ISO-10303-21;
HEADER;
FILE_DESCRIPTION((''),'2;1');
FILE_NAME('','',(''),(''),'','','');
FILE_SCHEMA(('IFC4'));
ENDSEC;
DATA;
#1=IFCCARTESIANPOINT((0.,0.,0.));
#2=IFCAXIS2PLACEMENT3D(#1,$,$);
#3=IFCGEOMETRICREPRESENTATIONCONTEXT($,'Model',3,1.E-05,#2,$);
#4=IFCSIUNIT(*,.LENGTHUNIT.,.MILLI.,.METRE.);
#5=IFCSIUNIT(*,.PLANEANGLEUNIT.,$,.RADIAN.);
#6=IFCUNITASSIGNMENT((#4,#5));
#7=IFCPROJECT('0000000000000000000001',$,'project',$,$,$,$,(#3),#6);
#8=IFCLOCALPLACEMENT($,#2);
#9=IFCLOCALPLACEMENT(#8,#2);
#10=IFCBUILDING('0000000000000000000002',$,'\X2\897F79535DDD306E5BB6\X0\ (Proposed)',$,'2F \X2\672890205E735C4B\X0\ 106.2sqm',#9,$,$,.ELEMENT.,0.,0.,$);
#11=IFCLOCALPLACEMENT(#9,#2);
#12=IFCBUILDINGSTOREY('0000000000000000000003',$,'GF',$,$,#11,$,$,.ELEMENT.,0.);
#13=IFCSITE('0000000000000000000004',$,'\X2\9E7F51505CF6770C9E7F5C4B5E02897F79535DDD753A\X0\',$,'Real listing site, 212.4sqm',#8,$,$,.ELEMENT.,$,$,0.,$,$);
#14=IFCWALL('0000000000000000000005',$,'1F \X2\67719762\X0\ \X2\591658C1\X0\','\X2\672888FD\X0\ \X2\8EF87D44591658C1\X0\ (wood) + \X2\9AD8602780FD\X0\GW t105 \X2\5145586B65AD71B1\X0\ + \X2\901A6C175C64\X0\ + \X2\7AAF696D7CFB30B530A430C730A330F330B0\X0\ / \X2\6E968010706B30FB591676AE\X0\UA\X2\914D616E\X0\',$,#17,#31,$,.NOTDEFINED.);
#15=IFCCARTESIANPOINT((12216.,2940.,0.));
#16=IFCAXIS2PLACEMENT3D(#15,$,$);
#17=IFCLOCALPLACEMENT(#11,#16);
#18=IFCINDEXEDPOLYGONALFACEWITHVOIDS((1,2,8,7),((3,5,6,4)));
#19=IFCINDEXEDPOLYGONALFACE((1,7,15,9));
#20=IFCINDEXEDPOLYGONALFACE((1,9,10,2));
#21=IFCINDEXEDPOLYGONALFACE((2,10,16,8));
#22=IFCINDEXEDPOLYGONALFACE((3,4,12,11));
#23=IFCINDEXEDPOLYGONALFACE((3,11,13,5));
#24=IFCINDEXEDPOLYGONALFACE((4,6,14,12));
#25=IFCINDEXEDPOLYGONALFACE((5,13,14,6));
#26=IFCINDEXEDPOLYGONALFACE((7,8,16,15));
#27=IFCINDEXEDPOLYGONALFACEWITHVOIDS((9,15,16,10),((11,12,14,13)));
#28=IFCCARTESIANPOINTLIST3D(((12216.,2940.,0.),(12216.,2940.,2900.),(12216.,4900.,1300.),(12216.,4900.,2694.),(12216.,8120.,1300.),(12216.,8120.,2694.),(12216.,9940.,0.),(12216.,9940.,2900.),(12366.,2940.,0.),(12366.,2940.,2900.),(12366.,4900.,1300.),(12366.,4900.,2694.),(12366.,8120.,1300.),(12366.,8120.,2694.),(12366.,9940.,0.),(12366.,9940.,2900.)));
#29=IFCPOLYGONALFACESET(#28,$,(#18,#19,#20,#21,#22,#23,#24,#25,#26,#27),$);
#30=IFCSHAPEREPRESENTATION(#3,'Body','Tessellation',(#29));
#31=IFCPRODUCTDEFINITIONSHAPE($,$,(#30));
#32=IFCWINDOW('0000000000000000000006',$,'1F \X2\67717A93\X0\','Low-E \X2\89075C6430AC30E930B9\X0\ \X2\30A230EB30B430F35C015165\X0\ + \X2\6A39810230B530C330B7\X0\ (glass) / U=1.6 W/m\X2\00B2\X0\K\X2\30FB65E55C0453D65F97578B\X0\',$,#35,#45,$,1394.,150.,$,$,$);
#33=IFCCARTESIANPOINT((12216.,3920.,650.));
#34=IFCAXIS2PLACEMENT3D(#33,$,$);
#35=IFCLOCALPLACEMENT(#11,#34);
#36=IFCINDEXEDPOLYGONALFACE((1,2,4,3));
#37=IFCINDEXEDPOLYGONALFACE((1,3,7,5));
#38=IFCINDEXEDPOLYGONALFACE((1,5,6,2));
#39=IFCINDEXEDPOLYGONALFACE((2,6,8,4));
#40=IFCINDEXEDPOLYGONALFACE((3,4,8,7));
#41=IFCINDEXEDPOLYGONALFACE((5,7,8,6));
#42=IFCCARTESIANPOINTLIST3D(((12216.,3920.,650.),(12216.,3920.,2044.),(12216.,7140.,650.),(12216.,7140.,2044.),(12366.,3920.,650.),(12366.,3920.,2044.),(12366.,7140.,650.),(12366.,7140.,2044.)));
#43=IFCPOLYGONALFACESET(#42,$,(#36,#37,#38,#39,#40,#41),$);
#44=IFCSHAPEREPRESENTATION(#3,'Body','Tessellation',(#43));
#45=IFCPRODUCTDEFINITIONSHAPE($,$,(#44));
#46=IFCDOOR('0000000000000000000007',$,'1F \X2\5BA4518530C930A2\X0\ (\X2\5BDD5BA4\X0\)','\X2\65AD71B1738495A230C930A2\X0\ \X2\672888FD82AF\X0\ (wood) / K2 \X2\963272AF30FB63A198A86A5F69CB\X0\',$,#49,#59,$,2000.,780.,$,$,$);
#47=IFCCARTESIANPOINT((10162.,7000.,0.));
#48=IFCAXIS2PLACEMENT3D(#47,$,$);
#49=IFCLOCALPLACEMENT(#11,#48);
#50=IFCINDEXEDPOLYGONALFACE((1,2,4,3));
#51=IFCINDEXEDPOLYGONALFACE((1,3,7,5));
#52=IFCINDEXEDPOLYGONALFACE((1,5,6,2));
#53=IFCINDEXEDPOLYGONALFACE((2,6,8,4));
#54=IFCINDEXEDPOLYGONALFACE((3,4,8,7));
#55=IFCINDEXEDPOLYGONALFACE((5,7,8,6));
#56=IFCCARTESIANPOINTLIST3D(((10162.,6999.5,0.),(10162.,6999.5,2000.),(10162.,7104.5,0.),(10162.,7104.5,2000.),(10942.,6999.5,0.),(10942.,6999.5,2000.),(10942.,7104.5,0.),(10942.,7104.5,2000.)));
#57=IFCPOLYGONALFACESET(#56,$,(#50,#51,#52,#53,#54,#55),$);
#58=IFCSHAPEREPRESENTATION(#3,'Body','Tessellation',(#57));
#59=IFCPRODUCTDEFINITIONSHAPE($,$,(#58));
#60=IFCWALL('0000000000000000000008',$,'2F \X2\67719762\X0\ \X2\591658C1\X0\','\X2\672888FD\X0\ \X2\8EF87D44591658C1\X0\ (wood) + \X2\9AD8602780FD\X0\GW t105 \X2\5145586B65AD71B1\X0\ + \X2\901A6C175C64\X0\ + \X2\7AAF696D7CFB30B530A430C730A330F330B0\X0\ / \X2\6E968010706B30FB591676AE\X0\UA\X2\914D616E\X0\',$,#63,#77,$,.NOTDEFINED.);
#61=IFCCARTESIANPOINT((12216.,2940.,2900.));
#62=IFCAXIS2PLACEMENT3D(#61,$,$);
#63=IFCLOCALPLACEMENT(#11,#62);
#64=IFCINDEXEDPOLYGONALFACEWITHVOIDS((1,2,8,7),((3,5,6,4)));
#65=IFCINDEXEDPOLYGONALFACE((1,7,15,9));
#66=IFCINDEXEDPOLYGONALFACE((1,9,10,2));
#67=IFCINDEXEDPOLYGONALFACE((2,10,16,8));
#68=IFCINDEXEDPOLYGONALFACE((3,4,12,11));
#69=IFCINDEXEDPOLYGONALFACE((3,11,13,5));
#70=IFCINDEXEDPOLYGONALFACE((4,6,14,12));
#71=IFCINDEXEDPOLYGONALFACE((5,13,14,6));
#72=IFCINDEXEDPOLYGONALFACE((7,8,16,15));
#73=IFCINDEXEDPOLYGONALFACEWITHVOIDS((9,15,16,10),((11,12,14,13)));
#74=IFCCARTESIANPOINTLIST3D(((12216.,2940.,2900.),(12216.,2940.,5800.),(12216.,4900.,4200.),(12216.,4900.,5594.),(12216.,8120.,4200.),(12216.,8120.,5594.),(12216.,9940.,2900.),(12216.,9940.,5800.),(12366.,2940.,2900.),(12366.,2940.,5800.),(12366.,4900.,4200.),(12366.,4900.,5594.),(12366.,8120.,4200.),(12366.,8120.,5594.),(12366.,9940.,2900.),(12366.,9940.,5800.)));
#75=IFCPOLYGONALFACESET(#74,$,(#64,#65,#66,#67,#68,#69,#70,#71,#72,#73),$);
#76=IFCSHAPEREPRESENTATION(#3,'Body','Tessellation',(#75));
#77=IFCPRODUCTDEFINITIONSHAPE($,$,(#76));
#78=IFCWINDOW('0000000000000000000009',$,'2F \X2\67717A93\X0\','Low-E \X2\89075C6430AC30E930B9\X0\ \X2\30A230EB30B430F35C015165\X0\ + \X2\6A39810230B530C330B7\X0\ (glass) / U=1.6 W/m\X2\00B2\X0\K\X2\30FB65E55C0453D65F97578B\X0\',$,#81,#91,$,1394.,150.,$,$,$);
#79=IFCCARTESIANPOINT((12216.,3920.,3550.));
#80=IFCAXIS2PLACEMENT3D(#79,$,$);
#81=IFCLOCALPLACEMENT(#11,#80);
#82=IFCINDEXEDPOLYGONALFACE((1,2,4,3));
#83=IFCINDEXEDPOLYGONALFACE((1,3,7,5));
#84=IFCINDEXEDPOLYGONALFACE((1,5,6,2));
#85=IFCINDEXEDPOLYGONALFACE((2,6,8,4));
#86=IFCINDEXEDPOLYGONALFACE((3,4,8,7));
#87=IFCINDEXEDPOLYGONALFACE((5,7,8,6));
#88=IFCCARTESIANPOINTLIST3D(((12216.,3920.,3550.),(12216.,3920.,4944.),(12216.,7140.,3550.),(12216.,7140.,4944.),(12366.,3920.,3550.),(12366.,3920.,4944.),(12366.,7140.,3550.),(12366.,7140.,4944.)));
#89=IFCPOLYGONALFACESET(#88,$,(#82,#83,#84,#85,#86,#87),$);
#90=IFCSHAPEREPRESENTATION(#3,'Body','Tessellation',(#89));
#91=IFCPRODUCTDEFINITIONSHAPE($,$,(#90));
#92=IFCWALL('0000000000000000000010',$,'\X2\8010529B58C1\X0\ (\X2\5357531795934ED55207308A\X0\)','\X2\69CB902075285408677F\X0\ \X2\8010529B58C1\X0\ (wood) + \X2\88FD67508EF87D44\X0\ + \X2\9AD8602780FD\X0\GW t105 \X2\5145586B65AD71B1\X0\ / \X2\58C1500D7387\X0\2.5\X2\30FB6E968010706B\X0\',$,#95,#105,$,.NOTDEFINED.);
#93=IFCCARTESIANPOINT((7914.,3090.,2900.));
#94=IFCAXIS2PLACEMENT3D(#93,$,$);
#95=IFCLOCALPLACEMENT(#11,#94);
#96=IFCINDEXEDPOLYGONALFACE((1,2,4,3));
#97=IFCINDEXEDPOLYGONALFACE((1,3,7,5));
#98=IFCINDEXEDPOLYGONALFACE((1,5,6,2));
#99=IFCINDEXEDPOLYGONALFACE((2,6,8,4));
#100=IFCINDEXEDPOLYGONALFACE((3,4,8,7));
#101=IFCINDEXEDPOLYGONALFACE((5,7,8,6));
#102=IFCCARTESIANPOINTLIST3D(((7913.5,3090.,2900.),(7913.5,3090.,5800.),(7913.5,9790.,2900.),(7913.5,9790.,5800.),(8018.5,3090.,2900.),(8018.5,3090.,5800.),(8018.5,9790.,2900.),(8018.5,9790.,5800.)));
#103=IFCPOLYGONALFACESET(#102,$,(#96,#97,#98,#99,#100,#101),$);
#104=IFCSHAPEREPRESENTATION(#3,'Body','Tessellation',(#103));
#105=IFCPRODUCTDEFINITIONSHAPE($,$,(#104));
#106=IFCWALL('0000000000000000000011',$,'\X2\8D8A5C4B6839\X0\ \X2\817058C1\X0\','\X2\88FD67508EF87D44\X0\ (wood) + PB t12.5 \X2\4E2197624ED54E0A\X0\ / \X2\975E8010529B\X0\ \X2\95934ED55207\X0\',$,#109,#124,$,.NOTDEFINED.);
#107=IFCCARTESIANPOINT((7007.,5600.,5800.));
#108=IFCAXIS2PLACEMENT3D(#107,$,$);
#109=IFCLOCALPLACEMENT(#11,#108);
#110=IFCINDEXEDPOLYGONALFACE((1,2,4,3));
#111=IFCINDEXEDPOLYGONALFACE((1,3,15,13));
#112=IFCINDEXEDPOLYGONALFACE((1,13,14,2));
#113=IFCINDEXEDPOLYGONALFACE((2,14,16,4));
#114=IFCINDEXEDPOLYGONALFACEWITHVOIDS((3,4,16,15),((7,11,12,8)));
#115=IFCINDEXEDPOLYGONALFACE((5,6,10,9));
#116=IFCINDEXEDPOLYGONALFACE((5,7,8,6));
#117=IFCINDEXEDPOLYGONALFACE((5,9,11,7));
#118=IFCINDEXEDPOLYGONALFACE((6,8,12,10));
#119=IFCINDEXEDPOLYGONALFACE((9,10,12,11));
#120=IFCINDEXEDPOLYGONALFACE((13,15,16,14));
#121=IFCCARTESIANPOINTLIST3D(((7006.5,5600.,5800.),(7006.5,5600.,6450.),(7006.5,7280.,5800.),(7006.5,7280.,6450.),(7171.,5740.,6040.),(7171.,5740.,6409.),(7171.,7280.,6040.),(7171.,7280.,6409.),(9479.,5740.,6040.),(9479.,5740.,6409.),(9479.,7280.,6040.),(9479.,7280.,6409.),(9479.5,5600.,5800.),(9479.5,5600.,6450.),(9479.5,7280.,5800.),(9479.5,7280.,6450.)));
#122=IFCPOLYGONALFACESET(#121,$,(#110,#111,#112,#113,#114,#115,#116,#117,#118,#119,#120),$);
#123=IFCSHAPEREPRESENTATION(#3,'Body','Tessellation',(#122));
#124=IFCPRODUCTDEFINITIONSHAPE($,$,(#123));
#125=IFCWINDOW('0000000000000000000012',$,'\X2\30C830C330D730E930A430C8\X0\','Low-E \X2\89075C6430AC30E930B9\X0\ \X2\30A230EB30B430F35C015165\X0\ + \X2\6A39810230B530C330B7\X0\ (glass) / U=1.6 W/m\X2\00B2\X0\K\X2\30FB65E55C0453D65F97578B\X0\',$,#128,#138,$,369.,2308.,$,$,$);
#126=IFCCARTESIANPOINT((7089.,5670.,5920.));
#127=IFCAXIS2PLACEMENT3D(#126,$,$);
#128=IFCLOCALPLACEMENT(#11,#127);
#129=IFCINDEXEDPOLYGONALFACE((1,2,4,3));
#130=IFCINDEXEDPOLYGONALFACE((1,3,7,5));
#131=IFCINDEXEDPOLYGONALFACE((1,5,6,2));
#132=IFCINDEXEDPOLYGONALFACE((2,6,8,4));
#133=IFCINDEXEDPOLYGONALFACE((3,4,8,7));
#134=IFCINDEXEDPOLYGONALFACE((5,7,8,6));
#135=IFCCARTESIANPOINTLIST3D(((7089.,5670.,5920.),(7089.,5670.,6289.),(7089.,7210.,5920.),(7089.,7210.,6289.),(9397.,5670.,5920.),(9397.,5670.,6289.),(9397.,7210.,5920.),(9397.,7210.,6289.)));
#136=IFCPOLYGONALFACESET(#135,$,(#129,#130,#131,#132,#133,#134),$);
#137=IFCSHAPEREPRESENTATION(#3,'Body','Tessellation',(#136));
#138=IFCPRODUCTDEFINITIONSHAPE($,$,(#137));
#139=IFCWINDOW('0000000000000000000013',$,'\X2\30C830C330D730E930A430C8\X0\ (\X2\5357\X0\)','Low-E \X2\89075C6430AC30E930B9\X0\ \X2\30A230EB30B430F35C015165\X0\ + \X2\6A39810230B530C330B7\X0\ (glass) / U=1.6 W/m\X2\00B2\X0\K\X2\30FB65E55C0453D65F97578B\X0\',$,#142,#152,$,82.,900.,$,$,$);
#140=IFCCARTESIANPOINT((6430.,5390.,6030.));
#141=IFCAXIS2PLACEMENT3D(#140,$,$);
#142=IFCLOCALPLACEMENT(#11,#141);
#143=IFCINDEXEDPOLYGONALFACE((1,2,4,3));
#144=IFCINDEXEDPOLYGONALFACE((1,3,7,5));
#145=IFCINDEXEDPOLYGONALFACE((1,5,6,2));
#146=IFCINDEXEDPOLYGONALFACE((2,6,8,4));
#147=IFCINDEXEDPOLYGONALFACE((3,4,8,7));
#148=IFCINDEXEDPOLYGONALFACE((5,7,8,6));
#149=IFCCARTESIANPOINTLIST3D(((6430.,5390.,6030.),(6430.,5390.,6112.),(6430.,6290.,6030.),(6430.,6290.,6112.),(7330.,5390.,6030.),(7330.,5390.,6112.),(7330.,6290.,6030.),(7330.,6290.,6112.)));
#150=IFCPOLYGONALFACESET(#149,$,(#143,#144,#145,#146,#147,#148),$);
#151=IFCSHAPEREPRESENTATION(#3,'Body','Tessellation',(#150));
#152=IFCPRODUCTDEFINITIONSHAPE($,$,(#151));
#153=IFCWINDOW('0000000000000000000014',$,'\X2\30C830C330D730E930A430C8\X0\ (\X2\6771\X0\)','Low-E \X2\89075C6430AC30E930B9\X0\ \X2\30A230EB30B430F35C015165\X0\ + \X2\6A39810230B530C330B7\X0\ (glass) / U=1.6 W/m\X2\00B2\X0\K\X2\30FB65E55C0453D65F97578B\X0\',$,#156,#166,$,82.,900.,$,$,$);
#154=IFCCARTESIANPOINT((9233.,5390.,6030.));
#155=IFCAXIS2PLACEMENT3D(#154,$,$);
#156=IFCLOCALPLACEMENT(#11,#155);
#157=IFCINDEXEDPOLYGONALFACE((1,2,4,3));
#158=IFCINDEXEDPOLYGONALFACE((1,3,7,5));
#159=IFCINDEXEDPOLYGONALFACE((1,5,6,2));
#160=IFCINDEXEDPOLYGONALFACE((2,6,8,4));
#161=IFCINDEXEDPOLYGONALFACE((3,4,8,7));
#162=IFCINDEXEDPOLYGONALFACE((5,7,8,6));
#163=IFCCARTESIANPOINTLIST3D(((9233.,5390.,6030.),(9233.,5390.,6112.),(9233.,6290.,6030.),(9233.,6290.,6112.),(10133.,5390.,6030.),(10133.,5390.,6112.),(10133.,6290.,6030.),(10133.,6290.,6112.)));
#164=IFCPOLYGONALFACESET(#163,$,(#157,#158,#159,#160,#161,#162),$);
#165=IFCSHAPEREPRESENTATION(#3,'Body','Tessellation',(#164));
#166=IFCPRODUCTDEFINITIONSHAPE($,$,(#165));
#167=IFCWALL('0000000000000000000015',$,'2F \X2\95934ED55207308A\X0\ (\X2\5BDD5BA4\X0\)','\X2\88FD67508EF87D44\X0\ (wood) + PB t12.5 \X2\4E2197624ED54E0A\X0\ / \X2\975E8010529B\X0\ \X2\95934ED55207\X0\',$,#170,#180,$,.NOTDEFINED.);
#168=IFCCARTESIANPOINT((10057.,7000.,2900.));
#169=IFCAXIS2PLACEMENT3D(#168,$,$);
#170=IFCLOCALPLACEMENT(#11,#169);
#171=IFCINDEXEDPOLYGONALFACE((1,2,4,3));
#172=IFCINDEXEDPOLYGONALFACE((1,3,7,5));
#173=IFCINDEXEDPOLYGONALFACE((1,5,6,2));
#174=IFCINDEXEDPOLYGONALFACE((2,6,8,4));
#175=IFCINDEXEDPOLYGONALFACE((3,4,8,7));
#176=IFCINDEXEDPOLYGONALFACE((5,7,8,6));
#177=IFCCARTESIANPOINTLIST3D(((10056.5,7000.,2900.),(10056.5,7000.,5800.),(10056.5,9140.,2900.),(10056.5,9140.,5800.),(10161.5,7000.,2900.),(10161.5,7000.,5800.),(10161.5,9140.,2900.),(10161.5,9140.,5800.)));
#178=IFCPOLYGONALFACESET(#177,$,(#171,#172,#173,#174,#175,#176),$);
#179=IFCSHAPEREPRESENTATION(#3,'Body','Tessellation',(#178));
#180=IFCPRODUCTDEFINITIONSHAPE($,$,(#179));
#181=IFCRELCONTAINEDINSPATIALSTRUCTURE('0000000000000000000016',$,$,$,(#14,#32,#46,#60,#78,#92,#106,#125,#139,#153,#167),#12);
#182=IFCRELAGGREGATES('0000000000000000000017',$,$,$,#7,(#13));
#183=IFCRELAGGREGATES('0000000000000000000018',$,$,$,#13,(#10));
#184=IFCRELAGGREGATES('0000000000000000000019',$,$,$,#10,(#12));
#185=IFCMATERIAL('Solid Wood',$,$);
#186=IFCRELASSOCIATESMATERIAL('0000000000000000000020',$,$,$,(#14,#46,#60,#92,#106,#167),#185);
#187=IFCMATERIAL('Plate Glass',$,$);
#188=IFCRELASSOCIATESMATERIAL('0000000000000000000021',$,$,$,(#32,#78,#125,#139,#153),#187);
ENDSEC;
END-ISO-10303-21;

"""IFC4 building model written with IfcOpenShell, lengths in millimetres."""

from ifc_helpers import new_model, si_unit, frame, frame_2d, origin, place, context, project, spatial, rectangle, extrude, material, element, fill, save


model = new_model("IFC4")

# Units and contexts
model_context = context("Model", 3, precision=1e-05, world=origin())
ifc_project = project(units=[si_unit("LENGTHUNIT", "METRE", prefix="MILLI"), si_unit("PLANEANGLEUNIT", "RADIAN")], contexts=[model_context])

# Site, building, storey
site_placement = place(None, origin())
site = spatial("IfcSite", under=ifc_project, at=site_placement, Name="鹿児島県鹿屋市西祓川町", ObjectType="Real listing site, 212.4sqm", CompositionType="ELEMENT", RefElevation=0.0)
building_placement = place(site_placement, origin())
building = spatial("IfcBuilding", under=site, at=building_placement, Name="西祓川の家 (Proposed)", ObjectType="2F 木造平屋 106.2sqm", CompositionType="ELEMENT", ElevationOfRefHeight=0.0, ElevationOfTerrain=0.0)
storey_placement = place(building_placement, origin())
storey = spatial("IfcBuildingStorey", under=building, at=storey_placement, Name="GF", CompositionType="ELEMENT", Elevation=0.0)

# Wall, opening, window
ifc_material_1 = material(Name="Solid Wood")
wall_1_placement = place(storey_placement, frame((12216.0, 2940.0, 0.0)))
wall_1 = element("IfcWall", 1, at=wall_1_placement, inside=storey, material=ifc_material_1, Name="1F 東面 外壁", Description="木製 軸組外壁 (wood) + 高性能GW t105 充填断熱 + 通気層 + 窯業系サイディング / 準耐火・外皮UA配慮", PredefinedType="NOTDEFINED", context=model_context, shape_type="SweptSolid", body=[
    extrude(rectangle(XDim=150.0, YDim=7000.0, at=frame_2d((75.0, 3500.0))), frame((12216.0, 2940.0, 0.0)), (0.0, 0.0, 1.0), 2900.0),
])
opening_1_placement = place(storey_placement, frame((12216.0, 3920.0, 650.0)))
opening_1 = element("IfcOpeningElement", 2, at=opening_1_placement, cuts=wall_1, PredefinedType="NOTDEFINED", context=model_context, shape_type="SweptSolid", body=[
    extrude(rectangle(XDim=150.0, YDim=3220.0, at=frame_2d((75.0, 1610.0))), frame((12216.0, 3920.0, 650.0)), (0.0, 0.0, 1.0), 1394.0),
])
ifc_material_2 = material(Name="Plate Glass")
window_1_placement = place(storey_placement, frame((12216.0, 3920.0, 650.0)))
window_1 = element("IfcWindow", 3, at=window_1_placement, inside=storey, material=ifc_material_2, Name="1F 東窓", Description="Low-E 複層ガラス アルゴン封入 + 樹脂サッシ (glass) / U=1.6 W/m²K・日射取得型", OverallHeight=1394.0, OverallWidth=150.0, context=model_context, shape_type="SweptSolid", body=[
    extrude(rectangle(XDim=150.0, YDim=3220.0, at=frame_2d((75.0, 1610.0))), frame((12216.0, 3920.0, 650.0)), (0.0, 0.0, 1.0), 1394.0),
])
fill(opening_1, window_1)

# Door
door_1_placement = place(storey_placement, frame((10162.0, 7000.0, 0.0)))
element("IfcDoor", 4, at=door_1_placement, inside=storey, material=ifc_material_1, Name="1F 室内ドア (寝室)", Description="断熱玄関ドア 木製芯 (wood) / K2 防犯・採風機構", OverallHeight=2000.0, OverallWidth=780.0, context=model_context, shape_type="SweptSolid", body=[
    extrude(rectangle(XDim=780.0, YDim=105.0, at=frame_2d((390.0, 52.0))), frame((10162.0, 7000.0, 0.0)), (0.0, 0.0, 1.0), 2000.0),
])

# Wall, opening, window
wall_2_placement = place(storey_placement, frame((12216.0, 2940.0, 2900.0)))
wall_2 = element("IfcWall", 5, at=wall_2_placement, inside=storey, material=ifc_material_1, Name="2F 東面 外壁", Description="木製 軸組外壁 (wood) + 高性能GW t105 充填断熱 + 通気層 + 窯業系サイディング / 準耐火・外皮UA配慮", PredefinedType="NOTDEFINED", context=model_context, shape_type="SweptSolid", body=[
    extrude(rectangle(XDim=150.0, YDim=7000.0, at=frame_2d((75.0, 3500.0))), frame((12216.0, 2940.0, 2900.0)), (0.0, 0.0, 1.0), 2900.0),
])
opening_2_placement = place(storey_placement, frame((12216.0, 3920.0, 3550.0)))
opening_2 = element("IfcOpeningElement", 6, at=opening_2_placement, cuts=wall_2, PredefinedType="NOTDEFINED", context=model_context, shape_type="SweptSolid", body=[
    extrude(rectangle(XDim=150.0, YDim=3220.0, at=frame_2d((75.0, 1610.0))), frame((12216.0, 3920.0, 3550.0)), (0.0, 0.0, 1.0), 1394.0),
])
window_2_placement = place(storey_placement, frame((12216.0, 3920.0, 3550.0)))
window_2 = element("IfcWindow", 7, at=window_2_placement, inside=storey, material=ifc_material_2, Name="2F 東窓", Description="Low-E 複層ガラス アルゴン封入 + 樹脂サッシ (glass) / U=1.6 W/m²K・日射取得型", OverallHeight=1394.0, OverallWidth=150.0, context=model_context, shape_type="SweptSolid", body=[
    extrude(rectangle(XDim=150.0, YDim=3220.0, at=frame_2d((75.0, 1610.0))), frame((12216.0, 3920.0, 3550.0)), (0.0, 0.0, 1.0), 1394.0),
])
fill(opening_2, window_2)

# Wall
wall_3_placement = place(storey_placement, frame((7914.0, 3090.0, 2900.0)))
element("IfcWall", 8, at=wall_3_placement, inside=storey, material=ifc_material_1, Name="耐力壁 (南北間仕切り)", Description="構造用合板 耐力壁 (wood) + 製材軸組 + 高性能GW t105 充填断熱 / 壁倍率2.5・準耐火", PredefinedType="NOTDEFINED", context=model_context, shape_type="SweptSolid", body=[
    extrude(rectangle(XDim=105.0, YDim=6700.0, at=frame_2d((52.0, 3350.0))), frame((7914.0, 3090.0, 2900.0)), (0.0, 0.0, 1.0), 2900.0),
])

# Wall, openings, windows
wall_4_placement = place(storey_placement, frame((7007.0, 5600.0, 5800.0)))
wall_4 = element("IfcWall", 9, at=wall_4_placement, inside=storey, material=ifc_material_1, Name="越屋根 腰壁", Description="製材軸組 (wood) + PB t12.5 両面仕上 / 非耐力 間仕切", PredefinedType="NOTDEFINED", context=model_context, shape_type="SweptSolid", body=[
    extrude(rectangle(XDim=2473.0, YDim=1680.0, at=frame_2d((1236.0, 840.0))), frame((7007.0, 5600.0, 5800.0)), (0.0, 0.0, 1.0), 650.0),
])
opening_3_placement = place(storey_placement, frame((7089.0, 5670.0, 5920.0)))
opening_3 = element("IfcOpeningElement", 10, at=opening_3_placement, cuts=wall_4, PredefinedType="NOTDEFINED", context=model_context, shape_type="SweptSolid", body=[
    extrude(rectangle(XDim=2308.0, YDim=1540.0, at=frame_2d((1154.0, 770.0))), frame((7089.0, 5670.0, 5920.0)), (0.0, 0.0, 1.0), 369.0),
])
opening_4_placement = place(storey_placement, frame((6430.0, 5390.0, 6030.0)))
opening_4 = element("IfcOpeningElement", 11, at=opening_4_placement, cuts=wall_4, PredefinedType="NOTDEFINED", context=model_context, shape_type="SweptSolid", body=[
    extrude(rectangle(XDim=900.0, YDim=900.0, at=frame_2d((450.0, 450.0))), frame((6430.0, 5390.0, 6030.0)), (0.0, 0.0, 1.0), 82.0),
])
opening_5_placement = place(storey_placement, frame((9233.0, 5390.0, 6030.0)))
opening_5 = element("IfcOpeningElement", 12, at=opening_5_placement, cuts=wall_4, PredefinedType="NOTDEFINED", context=model_context, shape_type="SweptSolid", body=[
    extrude(rectangle(XDim=900.0, YDim=900.0, at=frame_2d((450.0, 450.0))), frame((9233.0, 5390.0, 6030.0)), (0.0, 0.0, 1.0), 82.0),
])
window_3_placement = place(storey_placement, frame((7089.0, 5670.0, 5920.0)))
window_3 = element("IfcWindow", 13, at=window_3_placement, inside=storey, material=ifc_material_2, Name="トップライト", Description="Low-E 複層ガラス アルゴン封入 + 樹脂サッシ (glass) / U=1.6 W/m²K・日射取得型", OverallHeight=369.0, OverallWidth=2308.0, context=model_context, shape_type="SweptSolid", body=[
    extrude(rectangle(XDim=2308.0, YDim=1540.0, at=frame_2d((1154.0, 770.0))), frame((7089.0, 5670.0, 5920.0)), (0.0, 0.0, 1.0), 369.0),
])
fill(opening_3, window_3)
window_4_placement = place(storey_placement, frame((6430.0, 5390.0, 6030.0)))
window_4 = element("IfcWindow", 14, at=window_4_placement, inside=storey, material=ifc_material_2, Name="トップライト (南)", Description="Low-E 複層ガラス アルゴン封入 + 樹脂サッシ (glass) / U=1.6 W/m²K・日射取得型", OverallHeight=82.0, OverallWidth=900.0, context=model_context, shape_type="SweptSolid", body=[
    extrude(rectangle(XDim=900.0, YDim=900.0, at=frame_2d((450.0, 450.0))), frame((6430.0, 5390.0, 6030.0)), (0.0, 0.0, 1.0), 82.0),
])
fill(opening_4, window_4)
window_5_placement = place(storey_placement, frame((9233.0, 5390.0, 6030.0)))
window_5 = element("IfcWindow", 15, at=window_5_placement, inside=storey, material=ifc_material_2, Name="トップライト (東)", Description="Low-E 複層ガラス アルゴン封入 + 樹脂サッシ (glass) / U=1.6 W/m²K・日射取得型", OverallHeight=82.0, OverallWidth=900.0, context=model_context, shape_type="SweptSolid", body=[
    extrude(rectangle(XDim=900.0, YDim=900.0, at=frame_2d((450.0, 450.0))), frame((9233.0, 5390.0, 6030.0)), (0.0, 0.0, 1.0), 82.0),
])
fill(opening_5, window_5)

# Wall
wall_5_placement = place(storey_placement, frame((10057.0, 7000.0, 2900.0)))
element("IfcWall", 16, at=wall_5_placement, inside=storey, material=ifc_material_1, Name="2F 間仕切り (寝室)", Description="製材軸組 (wood) + PB t12.5 両面仕上 / 非耐力 間仕切", PredefinedType="NOTDEFINED", context=model_context, shape_type="SweptSolid", body=[
    extrude(rectangle(XDim=105.0, YDim=2140.0, at=frame_2d((52.0, 1070.0))), frame((10057.0, 7000.0, 2900.0)), (0.0, 0.0, 1.0), 2900.0),
])

save(model, "model.ifc")
